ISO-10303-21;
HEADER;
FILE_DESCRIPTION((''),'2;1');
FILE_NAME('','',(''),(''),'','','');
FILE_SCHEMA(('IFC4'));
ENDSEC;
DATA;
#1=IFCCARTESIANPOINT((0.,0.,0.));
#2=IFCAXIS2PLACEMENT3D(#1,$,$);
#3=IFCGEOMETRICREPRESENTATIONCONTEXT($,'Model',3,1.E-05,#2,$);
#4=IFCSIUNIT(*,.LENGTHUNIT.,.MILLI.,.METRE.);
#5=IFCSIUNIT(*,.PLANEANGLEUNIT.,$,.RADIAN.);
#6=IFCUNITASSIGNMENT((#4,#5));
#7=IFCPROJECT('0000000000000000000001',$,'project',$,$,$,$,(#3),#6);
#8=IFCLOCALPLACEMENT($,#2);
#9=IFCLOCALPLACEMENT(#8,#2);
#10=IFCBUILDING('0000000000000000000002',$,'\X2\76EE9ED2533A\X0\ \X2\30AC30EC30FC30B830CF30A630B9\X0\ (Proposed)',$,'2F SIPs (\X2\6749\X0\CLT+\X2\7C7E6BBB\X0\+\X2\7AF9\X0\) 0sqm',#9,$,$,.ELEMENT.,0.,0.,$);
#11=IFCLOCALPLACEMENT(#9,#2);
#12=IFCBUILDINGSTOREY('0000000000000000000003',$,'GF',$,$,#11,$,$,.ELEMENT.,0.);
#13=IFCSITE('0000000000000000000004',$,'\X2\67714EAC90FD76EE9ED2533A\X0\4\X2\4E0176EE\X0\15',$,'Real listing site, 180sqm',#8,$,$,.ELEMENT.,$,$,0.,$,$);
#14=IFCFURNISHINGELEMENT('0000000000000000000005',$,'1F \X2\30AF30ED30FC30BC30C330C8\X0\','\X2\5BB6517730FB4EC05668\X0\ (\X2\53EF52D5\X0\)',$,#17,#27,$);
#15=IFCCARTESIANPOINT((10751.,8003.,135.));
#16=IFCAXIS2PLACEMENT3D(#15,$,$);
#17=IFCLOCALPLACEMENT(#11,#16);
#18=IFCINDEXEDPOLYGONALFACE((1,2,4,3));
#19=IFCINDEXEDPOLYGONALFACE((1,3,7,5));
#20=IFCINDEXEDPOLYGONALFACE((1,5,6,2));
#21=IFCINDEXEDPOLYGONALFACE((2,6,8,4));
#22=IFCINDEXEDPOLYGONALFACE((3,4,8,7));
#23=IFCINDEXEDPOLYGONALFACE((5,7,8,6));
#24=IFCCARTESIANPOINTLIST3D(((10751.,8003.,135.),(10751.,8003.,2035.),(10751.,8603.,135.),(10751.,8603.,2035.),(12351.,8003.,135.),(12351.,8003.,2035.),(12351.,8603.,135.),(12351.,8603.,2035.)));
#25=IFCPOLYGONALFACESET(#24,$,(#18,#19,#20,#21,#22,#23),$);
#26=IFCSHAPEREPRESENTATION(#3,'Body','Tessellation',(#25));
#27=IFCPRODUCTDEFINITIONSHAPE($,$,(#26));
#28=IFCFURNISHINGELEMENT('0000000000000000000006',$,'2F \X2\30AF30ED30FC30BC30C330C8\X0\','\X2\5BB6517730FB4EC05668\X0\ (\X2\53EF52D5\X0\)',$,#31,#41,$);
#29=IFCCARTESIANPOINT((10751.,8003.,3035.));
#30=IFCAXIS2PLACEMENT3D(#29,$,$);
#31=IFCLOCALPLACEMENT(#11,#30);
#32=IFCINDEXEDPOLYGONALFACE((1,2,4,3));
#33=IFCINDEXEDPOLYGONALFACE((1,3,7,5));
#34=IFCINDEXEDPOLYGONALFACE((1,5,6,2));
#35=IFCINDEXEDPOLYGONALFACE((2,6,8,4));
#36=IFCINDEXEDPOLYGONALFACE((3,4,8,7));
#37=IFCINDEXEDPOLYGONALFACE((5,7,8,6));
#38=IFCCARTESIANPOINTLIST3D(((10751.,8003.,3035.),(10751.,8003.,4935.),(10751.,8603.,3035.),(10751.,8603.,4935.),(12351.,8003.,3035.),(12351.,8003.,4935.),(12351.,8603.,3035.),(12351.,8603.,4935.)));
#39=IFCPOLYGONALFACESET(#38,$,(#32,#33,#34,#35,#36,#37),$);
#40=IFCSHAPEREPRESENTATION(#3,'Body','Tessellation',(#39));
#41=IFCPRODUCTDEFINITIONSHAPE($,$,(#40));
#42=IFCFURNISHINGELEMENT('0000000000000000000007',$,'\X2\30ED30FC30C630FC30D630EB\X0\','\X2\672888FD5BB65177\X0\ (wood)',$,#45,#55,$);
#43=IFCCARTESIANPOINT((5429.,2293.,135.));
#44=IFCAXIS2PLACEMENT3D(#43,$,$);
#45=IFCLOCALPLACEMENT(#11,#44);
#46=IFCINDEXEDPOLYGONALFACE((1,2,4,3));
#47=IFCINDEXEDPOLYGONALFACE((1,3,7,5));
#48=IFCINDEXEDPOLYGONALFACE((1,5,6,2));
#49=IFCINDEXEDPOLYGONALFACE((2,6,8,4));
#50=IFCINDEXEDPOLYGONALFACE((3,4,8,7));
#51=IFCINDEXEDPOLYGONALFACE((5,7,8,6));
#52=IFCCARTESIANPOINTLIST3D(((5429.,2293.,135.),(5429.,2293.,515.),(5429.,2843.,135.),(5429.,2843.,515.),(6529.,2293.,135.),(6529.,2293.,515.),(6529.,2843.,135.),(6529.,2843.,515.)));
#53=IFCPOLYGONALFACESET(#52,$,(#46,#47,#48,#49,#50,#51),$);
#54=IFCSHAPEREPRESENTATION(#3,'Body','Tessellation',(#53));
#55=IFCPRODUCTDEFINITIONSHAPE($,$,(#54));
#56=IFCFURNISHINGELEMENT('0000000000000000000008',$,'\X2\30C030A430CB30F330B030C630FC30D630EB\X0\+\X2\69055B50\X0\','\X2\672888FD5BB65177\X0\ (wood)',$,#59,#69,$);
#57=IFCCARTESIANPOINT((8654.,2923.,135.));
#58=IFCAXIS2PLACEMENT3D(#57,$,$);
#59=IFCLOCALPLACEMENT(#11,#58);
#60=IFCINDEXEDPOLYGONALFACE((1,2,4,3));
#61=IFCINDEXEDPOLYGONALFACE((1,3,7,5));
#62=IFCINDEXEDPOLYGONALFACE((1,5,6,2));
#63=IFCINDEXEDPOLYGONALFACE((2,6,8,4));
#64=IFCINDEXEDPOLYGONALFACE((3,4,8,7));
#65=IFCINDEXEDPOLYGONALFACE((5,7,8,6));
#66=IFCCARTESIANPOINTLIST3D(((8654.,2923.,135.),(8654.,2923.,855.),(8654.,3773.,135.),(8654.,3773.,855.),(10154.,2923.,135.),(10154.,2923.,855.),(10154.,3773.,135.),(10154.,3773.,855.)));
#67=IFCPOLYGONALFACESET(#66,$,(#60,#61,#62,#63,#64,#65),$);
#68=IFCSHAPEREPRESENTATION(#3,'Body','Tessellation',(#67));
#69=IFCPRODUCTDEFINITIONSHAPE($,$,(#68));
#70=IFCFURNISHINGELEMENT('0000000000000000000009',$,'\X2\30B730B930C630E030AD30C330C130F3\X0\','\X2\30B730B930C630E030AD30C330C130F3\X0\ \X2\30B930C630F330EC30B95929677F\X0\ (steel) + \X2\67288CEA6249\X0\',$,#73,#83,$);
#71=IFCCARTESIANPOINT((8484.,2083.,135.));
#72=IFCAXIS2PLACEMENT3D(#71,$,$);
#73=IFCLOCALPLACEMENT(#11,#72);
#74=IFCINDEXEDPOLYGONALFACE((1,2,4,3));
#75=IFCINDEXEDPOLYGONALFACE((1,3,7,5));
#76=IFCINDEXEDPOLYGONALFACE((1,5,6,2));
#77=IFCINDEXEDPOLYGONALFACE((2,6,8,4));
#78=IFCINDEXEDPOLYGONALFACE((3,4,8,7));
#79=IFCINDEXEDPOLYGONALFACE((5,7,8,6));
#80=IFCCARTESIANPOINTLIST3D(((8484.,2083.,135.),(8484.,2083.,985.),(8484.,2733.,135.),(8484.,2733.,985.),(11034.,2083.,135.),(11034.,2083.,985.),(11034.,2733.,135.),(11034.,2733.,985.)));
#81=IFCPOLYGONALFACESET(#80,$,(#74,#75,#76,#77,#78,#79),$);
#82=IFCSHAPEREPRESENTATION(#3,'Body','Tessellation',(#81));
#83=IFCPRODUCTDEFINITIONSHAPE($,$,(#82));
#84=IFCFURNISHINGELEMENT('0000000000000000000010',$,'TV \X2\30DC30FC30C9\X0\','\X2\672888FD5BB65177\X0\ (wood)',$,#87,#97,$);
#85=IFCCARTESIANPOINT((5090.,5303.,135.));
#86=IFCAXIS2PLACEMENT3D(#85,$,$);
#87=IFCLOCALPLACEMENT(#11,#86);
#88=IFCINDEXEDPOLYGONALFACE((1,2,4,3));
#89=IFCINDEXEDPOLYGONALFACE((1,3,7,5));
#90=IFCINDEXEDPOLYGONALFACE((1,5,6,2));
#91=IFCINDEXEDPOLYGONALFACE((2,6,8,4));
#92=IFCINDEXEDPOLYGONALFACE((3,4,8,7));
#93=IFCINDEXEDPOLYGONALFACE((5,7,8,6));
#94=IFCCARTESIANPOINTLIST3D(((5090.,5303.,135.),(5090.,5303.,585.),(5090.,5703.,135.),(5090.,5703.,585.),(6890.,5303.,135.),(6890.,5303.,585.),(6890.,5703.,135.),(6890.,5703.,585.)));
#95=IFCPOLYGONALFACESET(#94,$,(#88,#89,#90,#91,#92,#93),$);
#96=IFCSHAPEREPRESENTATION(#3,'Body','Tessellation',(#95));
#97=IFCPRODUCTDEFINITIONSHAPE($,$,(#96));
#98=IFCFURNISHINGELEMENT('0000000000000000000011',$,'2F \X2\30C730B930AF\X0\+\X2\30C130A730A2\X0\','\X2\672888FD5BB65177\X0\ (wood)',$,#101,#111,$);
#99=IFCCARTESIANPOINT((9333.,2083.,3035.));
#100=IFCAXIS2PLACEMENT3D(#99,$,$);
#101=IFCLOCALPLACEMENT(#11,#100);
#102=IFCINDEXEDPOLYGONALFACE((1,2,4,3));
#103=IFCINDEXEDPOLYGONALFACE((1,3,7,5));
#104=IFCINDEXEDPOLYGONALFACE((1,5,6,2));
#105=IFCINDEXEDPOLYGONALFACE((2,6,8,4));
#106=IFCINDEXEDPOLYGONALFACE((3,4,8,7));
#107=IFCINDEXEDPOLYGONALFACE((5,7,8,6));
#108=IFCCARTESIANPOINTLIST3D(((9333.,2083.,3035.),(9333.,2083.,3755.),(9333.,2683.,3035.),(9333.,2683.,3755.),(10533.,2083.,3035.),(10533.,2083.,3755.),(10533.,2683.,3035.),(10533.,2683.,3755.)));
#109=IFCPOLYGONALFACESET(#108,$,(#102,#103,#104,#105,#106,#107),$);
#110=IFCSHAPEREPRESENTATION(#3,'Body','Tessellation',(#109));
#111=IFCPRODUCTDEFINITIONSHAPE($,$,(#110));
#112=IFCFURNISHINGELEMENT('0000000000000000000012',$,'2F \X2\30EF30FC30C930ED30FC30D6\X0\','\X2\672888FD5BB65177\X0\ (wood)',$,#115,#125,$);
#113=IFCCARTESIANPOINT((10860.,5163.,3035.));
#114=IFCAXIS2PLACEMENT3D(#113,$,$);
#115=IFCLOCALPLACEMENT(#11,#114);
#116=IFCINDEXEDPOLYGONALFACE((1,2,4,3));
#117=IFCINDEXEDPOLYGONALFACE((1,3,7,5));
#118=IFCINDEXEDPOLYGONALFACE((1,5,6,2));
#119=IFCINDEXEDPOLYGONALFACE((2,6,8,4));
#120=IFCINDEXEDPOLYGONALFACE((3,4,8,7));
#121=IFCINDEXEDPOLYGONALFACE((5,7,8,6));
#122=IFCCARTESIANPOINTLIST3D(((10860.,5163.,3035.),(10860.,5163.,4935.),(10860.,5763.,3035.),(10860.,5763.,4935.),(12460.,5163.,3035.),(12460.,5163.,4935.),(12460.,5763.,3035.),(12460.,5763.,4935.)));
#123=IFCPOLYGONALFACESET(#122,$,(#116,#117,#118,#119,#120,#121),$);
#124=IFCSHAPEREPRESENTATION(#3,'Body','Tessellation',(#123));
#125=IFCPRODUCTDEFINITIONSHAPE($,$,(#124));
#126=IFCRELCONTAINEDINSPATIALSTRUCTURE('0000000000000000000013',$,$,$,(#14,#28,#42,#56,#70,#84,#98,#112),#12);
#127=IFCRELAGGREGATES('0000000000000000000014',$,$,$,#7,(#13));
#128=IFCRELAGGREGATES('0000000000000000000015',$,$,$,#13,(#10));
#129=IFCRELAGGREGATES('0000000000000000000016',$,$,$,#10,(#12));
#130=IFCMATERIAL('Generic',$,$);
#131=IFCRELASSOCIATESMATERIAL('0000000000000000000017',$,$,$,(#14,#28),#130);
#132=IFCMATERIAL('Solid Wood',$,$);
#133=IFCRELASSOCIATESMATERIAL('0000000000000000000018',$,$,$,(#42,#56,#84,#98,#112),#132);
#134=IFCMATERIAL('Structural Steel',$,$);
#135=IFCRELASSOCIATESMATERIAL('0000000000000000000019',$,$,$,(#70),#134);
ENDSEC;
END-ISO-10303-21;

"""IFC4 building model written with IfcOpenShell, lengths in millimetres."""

from ifc_helpers import new_model, si_unit, frame, frame_2d, origin, place, context, project, spatial, rectangle, extrude, material, element, save


model = new_model("IFC4")

# Units and contexts
model_context = context("Model", 3, precision=1e-05, world=origin())
ifc_project = project(units=[si_unit("LENGTHUNIT", "METRE", prefix="MILLI"), si_unit("PLANEANGLEUNIT", "RADIAN")], contexts=[model_context])

# Site, building, storey
site_placement = place(None, origin())
site = spatial("IfcSite", under=ifc_project, at=site_placement, Name="東京都目黒区4丁目15", ObjectType="Real listing site, 180sqm", CompositionType="ELEMENT", RefElevation=0.0)
building_placement = place(site_placement, origin())
building = spatial("IfcBuilding", under=site, at=building_placement, Name="目黒区 ガレージハウス (Proposed)", ObjectType="2F SIPs (杉CLT+籾殻+竹) 0sqm", CompositionType="ELEMENT", ElevationOfRefHeight=0.0, ElevationOfTerrain=0.0)
storey_placement = place(building_placement, origin())
storey = spatial("IfcBuildingStorey", under=building, at=storey_placement, Name="GF", CompositionType="ELEMENT", Elevation=0.0)

# Shared definitions
ifc_material_1 = material(Name="Solid Wood")

# Shared definitions
ifc_material_2 = material(Name="Generic")

# Furnishing elements
furnishing_1_placement = place(storey_placement, frame((10751.0, 8003.0, 135.0)))
element("IfcFurnishingElement", 1, at=furnishing_1_placement, inside=storey, material=ifc_material_2, Name="1F クローゼット", Description="家具・什器 (可動)", context=model_context, shape_type="SweptSolid", body=[
    extrude(rectangle(XDim=1600.0, YDim=600.0, at=frame_2d((800.0, 300.0))), frame((10751.0, 8003.0, 135.0)), (0.0, 0.0, 1.0), 1900.0),
])
furnishing_2_placement = place(storey_placement, frame((10751.0, 8003.0, 3035.0)))
element("IfcFurnishingElement", 2, at=furnishing_2_placement, inside=storey, material=ifc_material_2, Name="2F クローゼット", Description="家具・什器 (可動)", context=model_context, shape_type="SweptSolid", body=[
    extrude(rectangle(XDim=1600.0, YDim=600.0, at=frame_2d((800.0, 300.0))), frame((10751.0, 8003.0, 3035.0)), (0.0, 0.0, 1.0), 1900.0),
])
furnishing_3_placement = place(storey_placement, frame((5429.0, 2293.0, 135.0)))
element("IfcFurnishingElement", 3, at=furnishing_3_placement, inside=storey, material=ifc_material_1, Name="ローテーブル", Description="木製家具 (wood)", context=model_context, shape_type="SweptSolid", body=[
    extrude(rectangle(XDim=1100.0, YDim=550.0, at=frame_2d((550.0, 275.0))), frame((5429.0, 2293.0, 135.0)), (0.0, 0.0, 1.0), 380.0),
])
furnishing_4_placement = place(storey_placement, frame((8654.0, 2923.0, 135.0)))
element("IfcFurnishingElement", 4, at=furnishing_4_placement, inside=storey, material=ifc_material_1, Name="ダイニングテーブル+椅子", Description="木製家具 (wood)", context=model_context, shape_type="SweptSolid", body=[
    extrude(rectangle(XDim=1500.0, YDim=850.0, at=frame_2d((750.0, 425.0))), frame((8654.0, 2923.0, 135.0)), (0.0, 0.0, 1.0), 720.0),
])
ifc_material_3 = material(Name="Structural Steel")
furnishing_5_placement = place(storey_placement, frame((8484.0, 2083.0, 135.0)))
element("IfcFurnishingElement", 5, at=furnishing_5_placement, inside=storey, material=ifc_material_3, Name="システムキッチン", Description="システムキッチン ステンレス天板 (steel) + 木質扉", context=model_context, shape_type="SweptSolid", body=[
    extrude(rectangle(XDim=2550.0, YDim=650.0, at=frame_2d((1275.0, 325.0))), frame((8484.0, 2083.0, 135.0)), (0.0, 0.0, 1.0), 850.0),
])
furnishing_6_placement = place(storey_placement, frame((5090.0, 5303.0, 135.0)))
element("IfcFurnishingElement", 6, at=furnishing_6_placement, inside=storey, material=ifc_material_1, Name="TV ボード", Description="木製家具 (wood)", context=model_context, shape_type="SweptSolid", body=[
    extrude(rectangle(XDim=1800.0, YDim=400.0, at=frame_2d((900.0, 200.0))), frame((5090.0, 5303.0, 135.0)), (0.0, 0.0, 1.0), 450.0),
])
furnishing_7_placement = place(storey_placement, frame((9333.0, 2083.0, 3035.0)))
element("IfcFurnishingElement", 7, at=furnishing_7_placement, inside=storey, material=ifc_material_1, Name="2F デスク+チェア", Description="木製家具 (wood)", context=model_context, shape_type="SweptSolid", body=[
    extrude(rectangle(XDim=1200.0, YDim=600.0, at=frame_2d((600.0, 300.0))), frame((9333.0, 2083.0, 3035.0)), (0.0, 0.0, 1.0), 720.0),
])
furnishing_8_placement = place(storey_placement, frame((10860.0, 5163.0, 3035.0)))
element("IfcFurnishingElement", 8, at=furnishing_8_placement, inside=storey, material=ifc_material_1, Name="2F ワードローブ", Description="木製家具 (wood)", context=model_context, shape_type="SweptSolid", body=[
    extrude(rectangle(XDim=1600.0, YDim=600.0, at=frame_2d((800.0, 300.0))), frame((10860.0, 5163.0, 3035.0)), (0.0, 0.0, 1.0), 1900.0),
])

save(model, "model.ifc")
